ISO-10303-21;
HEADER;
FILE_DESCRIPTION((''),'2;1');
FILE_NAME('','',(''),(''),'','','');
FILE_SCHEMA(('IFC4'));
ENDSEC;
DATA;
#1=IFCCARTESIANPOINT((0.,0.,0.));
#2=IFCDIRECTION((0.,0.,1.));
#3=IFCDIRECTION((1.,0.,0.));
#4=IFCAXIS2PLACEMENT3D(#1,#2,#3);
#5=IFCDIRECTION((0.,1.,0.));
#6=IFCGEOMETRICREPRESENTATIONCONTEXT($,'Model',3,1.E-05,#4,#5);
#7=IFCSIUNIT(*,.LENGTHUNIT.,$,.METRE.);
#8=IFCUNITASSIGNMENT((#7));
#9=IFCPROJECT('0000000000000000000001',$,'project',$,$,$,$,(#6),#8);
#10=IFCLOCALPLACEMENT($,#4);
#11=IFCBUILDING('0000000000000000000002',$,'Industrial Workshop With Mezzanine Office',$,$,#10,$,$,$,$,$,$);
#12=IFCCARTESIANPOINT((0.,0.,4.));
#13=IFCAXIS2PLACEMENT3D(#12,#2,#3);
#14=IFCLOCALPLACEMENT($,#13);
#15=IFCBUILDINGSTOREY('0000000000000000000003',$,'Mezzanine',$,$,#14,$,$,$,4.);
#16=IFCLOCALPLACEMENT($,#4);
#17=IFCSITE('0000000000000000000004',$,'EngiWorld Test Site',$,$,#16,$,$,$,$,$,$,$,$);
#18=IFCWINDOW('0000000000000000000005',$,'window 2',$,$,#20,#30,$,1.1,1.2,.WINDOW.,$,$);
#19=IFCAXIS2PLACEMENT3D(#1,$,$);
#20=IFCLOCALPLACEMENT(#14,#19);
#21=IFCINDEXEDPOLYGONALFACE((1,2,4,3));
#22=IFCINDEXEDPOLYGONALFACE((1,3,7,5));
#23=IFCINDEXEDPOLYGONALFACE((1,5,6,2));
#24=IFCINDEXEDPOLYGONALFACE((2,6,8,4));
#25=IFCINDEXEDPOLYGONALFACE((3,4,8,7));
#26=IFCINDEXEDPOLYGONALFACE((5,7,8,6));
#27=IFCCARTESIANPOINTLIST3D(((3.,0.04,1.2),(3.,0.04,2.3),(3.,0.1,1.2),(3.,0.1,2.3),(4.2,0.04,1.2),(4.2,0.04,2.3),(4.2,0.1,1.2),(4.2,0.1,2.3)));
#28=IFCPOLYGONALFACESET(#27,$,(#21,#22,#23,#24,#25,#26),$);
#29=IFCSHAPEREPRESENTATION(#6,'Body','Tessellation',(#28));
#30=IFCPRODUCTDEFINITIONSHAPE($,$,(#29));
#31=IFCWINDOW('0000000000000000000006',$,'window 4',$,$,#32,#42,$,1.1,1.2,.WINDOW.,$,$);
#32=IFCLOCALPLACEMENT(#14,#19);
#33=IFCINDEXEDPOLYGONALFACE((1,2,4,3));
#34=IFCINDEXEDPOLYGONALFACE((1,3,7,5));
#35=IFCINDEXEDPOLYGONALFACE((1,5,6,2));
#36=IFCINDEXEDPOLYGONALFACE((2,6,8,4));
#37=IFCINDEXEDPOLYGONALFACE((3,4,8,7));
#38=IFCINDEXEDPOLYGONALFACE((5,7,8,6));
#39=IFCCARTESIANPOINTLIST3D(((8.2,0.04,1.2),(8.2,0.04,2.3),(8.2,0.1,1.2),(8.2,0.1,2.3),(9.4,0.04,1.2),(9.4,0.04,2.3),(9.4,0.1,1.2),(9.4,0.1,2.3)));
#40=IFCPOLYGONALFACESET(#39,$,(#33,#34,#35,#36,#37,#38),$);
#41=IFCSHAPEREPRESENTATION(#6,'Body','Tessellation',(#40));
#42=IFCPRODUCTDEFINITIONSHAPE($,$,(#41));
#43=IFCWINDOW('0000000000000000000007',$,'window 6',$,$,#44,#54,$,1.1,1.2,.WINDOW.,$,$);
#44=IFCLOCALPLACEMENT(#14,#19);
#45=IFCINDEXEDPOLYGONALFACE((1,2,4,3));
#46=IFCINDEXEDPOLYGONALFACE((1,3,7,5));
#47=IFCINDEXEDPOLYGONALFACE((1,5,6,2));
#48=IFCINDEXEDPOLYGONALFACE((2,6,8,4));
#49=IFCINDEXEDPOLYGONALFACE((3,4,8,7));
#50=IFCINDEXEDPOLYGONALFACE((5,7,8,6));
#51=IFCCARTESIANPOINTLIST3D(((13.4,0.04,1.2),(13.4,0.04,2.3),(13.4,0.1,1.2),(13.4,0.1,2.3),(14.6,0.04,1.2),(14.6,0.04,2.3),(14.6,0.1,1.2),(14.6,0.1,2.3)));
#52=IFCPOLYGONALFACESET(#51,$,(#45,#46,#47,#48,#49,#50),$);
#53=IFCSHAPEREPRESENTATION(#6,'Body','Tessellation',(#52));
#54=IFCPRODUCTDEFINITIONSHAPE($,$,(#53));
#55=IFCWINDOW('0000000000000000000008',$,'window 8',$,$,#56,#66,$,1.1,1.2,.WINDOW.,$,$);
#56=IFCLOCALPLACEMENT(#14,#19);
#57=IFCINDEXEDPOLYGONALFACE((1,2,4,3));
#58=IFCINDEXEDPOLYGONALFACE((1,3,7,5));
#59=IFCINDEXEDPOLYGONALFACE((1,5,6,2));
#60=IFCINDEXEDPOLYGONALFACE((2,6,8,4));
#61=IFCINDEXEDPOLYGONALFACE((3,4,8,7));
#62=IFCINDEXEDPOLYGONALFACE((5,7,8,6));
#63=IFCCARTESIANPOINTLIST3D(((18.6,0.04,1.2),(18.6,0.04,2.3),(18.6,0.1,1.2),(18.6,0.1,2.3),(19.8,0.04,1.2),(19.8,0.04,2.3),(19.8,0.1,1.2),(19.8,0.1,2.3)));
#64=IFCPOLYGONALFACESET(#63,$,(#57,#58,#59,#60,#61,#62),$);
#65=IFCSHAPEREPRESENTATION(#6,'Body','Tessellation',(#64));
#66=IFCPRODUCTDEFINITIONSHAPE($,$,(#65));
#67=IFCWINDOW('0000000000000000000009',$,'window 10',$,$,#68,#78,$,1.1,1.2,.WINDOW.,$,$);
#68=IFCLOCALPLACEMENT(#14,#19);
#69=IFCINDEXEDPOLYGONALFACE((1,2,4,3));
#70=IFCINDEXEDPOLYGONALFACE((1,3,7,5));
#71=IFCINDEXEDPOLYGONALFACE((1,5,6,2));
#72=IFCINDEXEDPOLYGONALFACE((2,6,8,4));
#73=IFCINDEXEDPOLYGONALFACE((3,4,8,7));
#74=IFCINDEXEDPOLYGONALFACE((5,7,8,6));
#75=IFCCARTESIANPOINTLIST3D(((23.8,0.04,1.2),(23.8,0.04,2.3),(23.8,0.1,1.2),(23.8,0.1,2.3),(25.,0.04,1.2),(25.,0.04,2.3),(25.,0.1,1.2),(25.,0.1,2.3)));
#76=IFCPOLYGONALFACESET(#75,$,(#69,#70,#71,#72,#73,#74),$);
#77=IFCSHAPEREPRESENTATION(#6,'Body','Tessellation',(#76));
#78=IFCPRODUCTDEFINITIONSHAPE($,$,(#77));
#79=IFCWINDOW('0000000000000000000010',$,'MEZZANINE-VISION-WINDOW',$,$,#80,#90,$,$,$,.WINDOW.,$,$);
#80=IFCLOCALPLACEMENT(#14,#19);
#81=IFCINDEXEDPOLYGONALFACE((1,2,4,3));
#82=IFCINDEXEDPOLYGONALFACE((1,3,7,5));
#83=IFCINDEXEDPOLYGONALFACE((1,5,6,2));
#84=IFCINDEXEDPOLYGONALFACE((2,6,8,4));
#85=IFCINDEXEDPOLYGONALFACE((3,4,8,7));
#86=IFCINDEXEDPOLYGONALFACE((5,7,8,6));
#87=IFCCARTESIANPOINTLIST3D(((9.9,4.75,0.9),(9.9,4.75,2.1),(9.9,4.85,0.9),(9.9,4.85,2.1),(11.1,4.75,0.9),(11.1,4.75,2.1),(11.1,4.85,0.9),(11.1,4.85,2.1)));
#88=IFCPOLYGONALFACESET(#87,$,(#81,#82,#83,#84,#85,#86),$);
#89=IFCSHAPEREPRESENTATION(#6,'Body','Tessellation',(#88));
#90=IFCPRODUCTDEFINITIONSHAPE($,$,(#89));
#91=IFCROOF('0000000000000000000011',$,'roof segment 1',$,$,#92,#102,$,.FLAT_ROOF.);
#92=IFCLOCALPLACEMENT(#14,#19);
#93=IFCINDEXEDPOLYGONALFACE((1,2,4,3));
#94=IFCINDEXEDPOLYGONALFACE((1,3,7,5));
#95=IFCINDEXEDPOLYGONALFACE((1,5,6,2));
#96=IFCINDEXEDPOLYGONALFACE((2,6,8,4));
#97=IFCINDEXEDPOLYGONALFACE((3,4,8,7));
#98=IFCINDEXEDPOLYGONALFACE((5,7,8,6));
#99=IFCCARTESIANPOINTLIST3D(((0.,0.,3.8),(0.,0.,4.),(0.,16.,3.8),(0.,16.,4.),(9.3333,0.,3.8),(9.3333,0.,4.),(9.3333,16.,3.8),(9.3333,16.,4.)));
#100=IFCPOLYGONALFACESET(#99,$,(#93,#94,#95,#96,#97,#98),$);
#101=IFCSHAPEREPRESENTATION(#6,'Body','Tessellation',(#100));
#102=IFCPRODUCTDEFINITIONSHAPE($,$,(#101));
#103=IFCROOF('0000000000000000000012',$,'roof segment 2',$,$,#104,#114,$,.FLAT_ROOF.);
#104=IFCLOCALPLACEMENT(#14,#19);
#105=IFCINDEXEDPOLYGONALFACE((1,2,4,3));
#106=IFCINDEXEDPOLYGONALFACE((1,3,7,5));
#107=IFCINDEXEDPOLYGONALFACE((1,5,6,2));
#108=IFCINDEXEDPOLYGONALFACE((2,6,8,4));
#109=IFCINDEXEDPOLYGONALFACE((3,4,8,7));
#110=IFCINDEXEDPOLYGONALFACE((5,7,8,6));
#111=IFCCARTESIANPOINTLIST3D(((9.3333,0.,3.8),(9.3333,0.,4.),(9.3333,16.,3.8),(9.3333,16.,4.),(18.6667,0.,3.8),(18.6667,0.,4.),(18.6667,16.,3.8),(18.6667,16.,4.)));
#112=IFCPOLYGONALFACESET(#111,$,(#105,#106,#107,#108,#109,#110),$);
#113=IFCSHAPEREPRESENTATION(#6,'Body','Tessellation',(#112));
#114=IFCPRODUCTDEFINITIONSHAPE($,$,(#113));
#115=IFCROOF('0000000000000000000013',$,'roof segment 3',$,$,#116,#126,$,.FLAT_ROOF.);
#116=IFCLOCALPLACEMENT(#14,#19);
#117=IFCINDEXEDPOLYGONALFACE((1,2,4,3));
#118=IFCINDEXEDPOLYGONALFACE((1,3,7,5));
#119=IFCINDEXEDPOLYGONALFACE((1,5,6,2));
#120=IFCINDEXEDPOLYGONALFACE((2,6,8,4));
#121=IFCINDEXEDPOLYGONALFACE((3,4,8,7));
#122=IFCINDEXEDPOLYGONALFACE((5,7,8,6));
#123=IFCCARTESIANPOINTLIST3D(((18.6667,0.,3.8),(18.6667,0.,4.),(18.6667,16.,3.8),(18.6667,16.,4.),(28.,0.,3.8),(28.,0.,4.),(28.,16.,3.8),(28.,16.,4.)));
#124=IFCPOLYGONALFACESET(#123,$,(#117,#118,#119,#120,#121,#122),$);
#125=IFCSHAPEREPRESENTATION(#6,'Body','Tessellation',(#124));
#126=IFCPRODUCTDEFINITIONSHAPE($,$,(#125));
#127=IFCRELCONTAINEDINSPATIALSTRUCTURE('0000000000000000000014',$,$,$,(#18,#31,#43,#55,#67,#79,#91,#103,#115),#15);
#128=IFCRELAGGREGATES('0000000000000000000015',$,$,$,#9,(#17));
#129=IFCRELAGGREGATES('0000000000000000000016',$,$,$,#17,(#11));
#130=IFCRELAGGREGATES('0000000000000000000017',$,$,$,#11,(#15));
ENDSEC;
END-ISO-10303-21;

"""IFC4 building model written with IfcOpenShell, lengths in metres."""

from ifc_helpers import new_model, si_unit, direction, frame, origin, origin_with_axes, origin_2d, origin_2d_with_axis, place, context, project, spatial, rectangle, extrude, element, save


model = new_model("IFC4")

# Units and contexts
model_context = context("Model", 3, precision=1e-05, world=origin_with_axes(), true_north=direction((0.0, 1.0, 0.0)))
ifc_project = project(units=[si_unit("LENGTHUNIT", "METRE")], contexts=[model_context])

# Site, building, storey
site_placement = place(None, origin_with_axes())
site = spatial("IfcSite", under=ifc_project, at=site_placement, Name="EngiWorld Test Site")
building_placement = place(None, origin_with_axes())
building = spatial("IfcBuilding", under=site, at=building_placement, Name="Industrial Workshop With Mezzanine Office")
storey_placement = place(None, frame((0.0, 0.0, 4.0), z_axis=(0.0, 0.0, 1.0), x_axis=(1.0, 0.0, 0.0)))
storey = spatial("IfcBuildingStorey", under=building, at=storey_placement, Name="Mezzanine", Elevation=4.0)

# Windows
for number, where, z_axis, x_axis, name in (
    (1, (3.6, 0.07, 5.2), (0.0, 0.0, 1.0), (1.0, 0.0, 0.0), "window 2"),
    (2, (8.8, 0.07, 5.2), (0.0, 0.0, 1.0), (1.0, 0.0, 0.0), "window 4"),
    (3, (14.0, 0.07, 5.2), (0.0, 0.0, 1.0), (1.0, 0.0, 0.0), "window 6"),
    (4, (19.2, 0.07, 5.2), (0.0, 0.0, 1.0), (1.0, 0.0, 0.0), "window 8"),
    (5, (24.4, 0.07, 5.2), (0.0, 0.0, 1.0), (1.0, 0.0, 0.0), "window 10"),
):
    element("IfcWindow", number, at=place(None, frame(where, z_axis=z_axis, x_axis=x_axis)), inside=storey, Name=name, OverallHeight=1.1, OverallWidth=1.2, PredefinedType="WINDOW", context=model_context, shape_type="SweptSolid", body=[
        extrude(rectangle(XDim=1.2, YDim=0.06, at=origin_2d_with_axis()), origin_with_axes(), (0.0, 0.0, 1.0), 1.1),
    ])
window_placement = place(None, frame((10.5, 4.8, 4.9)))
element("IfcWindow", 6, at=window_placement, inside=storey, Name="MEZZANINE-VISION-WINDOW", PredefinedType="WINDOW", context=model_context, shape_type="SweptSolid", body=[
    extrude(rectangle(XDim=1.2, YDim=0.1, at=origin_2d()), origin(), (0.0, 0.0, 1.0), 1.2),
])

# Roofs
for number, where, z_axis, x_axis, name in (
    (7, (4.6667, 8.0, 7.8), (0.0, 0.0, 1.0), (1.0, 0.0, 0.0), "roof segment 1"),
    (8, (14.0, 8.0, 7.8), (0.0, 0.0, 1.0), (1.0, 0.0, 0.0), "roof segment 2"),
    (9, (23.3333, 8.0, 7.8), (0.0, 0.0, 1.0), (1.0, 0.0, 0.0), "roof segment 3"),
):
    element("IfcRoof", number, at=place(None, frame(where, z_axis=z_axis, x_axis=x_axis)), inside=storey, Name=name, PredefinedType="FLAT_ROOF", context=model_context, shape_type="SweptSolid", body=[
        extrude(rectangle(XDim=9.3333, YDim=16.0, at=origin_2d_with_axis()), origin_with_axes(), (0.0, 0.0, 1.0), 0.2),
    ])

save(model, "model.ifc")
